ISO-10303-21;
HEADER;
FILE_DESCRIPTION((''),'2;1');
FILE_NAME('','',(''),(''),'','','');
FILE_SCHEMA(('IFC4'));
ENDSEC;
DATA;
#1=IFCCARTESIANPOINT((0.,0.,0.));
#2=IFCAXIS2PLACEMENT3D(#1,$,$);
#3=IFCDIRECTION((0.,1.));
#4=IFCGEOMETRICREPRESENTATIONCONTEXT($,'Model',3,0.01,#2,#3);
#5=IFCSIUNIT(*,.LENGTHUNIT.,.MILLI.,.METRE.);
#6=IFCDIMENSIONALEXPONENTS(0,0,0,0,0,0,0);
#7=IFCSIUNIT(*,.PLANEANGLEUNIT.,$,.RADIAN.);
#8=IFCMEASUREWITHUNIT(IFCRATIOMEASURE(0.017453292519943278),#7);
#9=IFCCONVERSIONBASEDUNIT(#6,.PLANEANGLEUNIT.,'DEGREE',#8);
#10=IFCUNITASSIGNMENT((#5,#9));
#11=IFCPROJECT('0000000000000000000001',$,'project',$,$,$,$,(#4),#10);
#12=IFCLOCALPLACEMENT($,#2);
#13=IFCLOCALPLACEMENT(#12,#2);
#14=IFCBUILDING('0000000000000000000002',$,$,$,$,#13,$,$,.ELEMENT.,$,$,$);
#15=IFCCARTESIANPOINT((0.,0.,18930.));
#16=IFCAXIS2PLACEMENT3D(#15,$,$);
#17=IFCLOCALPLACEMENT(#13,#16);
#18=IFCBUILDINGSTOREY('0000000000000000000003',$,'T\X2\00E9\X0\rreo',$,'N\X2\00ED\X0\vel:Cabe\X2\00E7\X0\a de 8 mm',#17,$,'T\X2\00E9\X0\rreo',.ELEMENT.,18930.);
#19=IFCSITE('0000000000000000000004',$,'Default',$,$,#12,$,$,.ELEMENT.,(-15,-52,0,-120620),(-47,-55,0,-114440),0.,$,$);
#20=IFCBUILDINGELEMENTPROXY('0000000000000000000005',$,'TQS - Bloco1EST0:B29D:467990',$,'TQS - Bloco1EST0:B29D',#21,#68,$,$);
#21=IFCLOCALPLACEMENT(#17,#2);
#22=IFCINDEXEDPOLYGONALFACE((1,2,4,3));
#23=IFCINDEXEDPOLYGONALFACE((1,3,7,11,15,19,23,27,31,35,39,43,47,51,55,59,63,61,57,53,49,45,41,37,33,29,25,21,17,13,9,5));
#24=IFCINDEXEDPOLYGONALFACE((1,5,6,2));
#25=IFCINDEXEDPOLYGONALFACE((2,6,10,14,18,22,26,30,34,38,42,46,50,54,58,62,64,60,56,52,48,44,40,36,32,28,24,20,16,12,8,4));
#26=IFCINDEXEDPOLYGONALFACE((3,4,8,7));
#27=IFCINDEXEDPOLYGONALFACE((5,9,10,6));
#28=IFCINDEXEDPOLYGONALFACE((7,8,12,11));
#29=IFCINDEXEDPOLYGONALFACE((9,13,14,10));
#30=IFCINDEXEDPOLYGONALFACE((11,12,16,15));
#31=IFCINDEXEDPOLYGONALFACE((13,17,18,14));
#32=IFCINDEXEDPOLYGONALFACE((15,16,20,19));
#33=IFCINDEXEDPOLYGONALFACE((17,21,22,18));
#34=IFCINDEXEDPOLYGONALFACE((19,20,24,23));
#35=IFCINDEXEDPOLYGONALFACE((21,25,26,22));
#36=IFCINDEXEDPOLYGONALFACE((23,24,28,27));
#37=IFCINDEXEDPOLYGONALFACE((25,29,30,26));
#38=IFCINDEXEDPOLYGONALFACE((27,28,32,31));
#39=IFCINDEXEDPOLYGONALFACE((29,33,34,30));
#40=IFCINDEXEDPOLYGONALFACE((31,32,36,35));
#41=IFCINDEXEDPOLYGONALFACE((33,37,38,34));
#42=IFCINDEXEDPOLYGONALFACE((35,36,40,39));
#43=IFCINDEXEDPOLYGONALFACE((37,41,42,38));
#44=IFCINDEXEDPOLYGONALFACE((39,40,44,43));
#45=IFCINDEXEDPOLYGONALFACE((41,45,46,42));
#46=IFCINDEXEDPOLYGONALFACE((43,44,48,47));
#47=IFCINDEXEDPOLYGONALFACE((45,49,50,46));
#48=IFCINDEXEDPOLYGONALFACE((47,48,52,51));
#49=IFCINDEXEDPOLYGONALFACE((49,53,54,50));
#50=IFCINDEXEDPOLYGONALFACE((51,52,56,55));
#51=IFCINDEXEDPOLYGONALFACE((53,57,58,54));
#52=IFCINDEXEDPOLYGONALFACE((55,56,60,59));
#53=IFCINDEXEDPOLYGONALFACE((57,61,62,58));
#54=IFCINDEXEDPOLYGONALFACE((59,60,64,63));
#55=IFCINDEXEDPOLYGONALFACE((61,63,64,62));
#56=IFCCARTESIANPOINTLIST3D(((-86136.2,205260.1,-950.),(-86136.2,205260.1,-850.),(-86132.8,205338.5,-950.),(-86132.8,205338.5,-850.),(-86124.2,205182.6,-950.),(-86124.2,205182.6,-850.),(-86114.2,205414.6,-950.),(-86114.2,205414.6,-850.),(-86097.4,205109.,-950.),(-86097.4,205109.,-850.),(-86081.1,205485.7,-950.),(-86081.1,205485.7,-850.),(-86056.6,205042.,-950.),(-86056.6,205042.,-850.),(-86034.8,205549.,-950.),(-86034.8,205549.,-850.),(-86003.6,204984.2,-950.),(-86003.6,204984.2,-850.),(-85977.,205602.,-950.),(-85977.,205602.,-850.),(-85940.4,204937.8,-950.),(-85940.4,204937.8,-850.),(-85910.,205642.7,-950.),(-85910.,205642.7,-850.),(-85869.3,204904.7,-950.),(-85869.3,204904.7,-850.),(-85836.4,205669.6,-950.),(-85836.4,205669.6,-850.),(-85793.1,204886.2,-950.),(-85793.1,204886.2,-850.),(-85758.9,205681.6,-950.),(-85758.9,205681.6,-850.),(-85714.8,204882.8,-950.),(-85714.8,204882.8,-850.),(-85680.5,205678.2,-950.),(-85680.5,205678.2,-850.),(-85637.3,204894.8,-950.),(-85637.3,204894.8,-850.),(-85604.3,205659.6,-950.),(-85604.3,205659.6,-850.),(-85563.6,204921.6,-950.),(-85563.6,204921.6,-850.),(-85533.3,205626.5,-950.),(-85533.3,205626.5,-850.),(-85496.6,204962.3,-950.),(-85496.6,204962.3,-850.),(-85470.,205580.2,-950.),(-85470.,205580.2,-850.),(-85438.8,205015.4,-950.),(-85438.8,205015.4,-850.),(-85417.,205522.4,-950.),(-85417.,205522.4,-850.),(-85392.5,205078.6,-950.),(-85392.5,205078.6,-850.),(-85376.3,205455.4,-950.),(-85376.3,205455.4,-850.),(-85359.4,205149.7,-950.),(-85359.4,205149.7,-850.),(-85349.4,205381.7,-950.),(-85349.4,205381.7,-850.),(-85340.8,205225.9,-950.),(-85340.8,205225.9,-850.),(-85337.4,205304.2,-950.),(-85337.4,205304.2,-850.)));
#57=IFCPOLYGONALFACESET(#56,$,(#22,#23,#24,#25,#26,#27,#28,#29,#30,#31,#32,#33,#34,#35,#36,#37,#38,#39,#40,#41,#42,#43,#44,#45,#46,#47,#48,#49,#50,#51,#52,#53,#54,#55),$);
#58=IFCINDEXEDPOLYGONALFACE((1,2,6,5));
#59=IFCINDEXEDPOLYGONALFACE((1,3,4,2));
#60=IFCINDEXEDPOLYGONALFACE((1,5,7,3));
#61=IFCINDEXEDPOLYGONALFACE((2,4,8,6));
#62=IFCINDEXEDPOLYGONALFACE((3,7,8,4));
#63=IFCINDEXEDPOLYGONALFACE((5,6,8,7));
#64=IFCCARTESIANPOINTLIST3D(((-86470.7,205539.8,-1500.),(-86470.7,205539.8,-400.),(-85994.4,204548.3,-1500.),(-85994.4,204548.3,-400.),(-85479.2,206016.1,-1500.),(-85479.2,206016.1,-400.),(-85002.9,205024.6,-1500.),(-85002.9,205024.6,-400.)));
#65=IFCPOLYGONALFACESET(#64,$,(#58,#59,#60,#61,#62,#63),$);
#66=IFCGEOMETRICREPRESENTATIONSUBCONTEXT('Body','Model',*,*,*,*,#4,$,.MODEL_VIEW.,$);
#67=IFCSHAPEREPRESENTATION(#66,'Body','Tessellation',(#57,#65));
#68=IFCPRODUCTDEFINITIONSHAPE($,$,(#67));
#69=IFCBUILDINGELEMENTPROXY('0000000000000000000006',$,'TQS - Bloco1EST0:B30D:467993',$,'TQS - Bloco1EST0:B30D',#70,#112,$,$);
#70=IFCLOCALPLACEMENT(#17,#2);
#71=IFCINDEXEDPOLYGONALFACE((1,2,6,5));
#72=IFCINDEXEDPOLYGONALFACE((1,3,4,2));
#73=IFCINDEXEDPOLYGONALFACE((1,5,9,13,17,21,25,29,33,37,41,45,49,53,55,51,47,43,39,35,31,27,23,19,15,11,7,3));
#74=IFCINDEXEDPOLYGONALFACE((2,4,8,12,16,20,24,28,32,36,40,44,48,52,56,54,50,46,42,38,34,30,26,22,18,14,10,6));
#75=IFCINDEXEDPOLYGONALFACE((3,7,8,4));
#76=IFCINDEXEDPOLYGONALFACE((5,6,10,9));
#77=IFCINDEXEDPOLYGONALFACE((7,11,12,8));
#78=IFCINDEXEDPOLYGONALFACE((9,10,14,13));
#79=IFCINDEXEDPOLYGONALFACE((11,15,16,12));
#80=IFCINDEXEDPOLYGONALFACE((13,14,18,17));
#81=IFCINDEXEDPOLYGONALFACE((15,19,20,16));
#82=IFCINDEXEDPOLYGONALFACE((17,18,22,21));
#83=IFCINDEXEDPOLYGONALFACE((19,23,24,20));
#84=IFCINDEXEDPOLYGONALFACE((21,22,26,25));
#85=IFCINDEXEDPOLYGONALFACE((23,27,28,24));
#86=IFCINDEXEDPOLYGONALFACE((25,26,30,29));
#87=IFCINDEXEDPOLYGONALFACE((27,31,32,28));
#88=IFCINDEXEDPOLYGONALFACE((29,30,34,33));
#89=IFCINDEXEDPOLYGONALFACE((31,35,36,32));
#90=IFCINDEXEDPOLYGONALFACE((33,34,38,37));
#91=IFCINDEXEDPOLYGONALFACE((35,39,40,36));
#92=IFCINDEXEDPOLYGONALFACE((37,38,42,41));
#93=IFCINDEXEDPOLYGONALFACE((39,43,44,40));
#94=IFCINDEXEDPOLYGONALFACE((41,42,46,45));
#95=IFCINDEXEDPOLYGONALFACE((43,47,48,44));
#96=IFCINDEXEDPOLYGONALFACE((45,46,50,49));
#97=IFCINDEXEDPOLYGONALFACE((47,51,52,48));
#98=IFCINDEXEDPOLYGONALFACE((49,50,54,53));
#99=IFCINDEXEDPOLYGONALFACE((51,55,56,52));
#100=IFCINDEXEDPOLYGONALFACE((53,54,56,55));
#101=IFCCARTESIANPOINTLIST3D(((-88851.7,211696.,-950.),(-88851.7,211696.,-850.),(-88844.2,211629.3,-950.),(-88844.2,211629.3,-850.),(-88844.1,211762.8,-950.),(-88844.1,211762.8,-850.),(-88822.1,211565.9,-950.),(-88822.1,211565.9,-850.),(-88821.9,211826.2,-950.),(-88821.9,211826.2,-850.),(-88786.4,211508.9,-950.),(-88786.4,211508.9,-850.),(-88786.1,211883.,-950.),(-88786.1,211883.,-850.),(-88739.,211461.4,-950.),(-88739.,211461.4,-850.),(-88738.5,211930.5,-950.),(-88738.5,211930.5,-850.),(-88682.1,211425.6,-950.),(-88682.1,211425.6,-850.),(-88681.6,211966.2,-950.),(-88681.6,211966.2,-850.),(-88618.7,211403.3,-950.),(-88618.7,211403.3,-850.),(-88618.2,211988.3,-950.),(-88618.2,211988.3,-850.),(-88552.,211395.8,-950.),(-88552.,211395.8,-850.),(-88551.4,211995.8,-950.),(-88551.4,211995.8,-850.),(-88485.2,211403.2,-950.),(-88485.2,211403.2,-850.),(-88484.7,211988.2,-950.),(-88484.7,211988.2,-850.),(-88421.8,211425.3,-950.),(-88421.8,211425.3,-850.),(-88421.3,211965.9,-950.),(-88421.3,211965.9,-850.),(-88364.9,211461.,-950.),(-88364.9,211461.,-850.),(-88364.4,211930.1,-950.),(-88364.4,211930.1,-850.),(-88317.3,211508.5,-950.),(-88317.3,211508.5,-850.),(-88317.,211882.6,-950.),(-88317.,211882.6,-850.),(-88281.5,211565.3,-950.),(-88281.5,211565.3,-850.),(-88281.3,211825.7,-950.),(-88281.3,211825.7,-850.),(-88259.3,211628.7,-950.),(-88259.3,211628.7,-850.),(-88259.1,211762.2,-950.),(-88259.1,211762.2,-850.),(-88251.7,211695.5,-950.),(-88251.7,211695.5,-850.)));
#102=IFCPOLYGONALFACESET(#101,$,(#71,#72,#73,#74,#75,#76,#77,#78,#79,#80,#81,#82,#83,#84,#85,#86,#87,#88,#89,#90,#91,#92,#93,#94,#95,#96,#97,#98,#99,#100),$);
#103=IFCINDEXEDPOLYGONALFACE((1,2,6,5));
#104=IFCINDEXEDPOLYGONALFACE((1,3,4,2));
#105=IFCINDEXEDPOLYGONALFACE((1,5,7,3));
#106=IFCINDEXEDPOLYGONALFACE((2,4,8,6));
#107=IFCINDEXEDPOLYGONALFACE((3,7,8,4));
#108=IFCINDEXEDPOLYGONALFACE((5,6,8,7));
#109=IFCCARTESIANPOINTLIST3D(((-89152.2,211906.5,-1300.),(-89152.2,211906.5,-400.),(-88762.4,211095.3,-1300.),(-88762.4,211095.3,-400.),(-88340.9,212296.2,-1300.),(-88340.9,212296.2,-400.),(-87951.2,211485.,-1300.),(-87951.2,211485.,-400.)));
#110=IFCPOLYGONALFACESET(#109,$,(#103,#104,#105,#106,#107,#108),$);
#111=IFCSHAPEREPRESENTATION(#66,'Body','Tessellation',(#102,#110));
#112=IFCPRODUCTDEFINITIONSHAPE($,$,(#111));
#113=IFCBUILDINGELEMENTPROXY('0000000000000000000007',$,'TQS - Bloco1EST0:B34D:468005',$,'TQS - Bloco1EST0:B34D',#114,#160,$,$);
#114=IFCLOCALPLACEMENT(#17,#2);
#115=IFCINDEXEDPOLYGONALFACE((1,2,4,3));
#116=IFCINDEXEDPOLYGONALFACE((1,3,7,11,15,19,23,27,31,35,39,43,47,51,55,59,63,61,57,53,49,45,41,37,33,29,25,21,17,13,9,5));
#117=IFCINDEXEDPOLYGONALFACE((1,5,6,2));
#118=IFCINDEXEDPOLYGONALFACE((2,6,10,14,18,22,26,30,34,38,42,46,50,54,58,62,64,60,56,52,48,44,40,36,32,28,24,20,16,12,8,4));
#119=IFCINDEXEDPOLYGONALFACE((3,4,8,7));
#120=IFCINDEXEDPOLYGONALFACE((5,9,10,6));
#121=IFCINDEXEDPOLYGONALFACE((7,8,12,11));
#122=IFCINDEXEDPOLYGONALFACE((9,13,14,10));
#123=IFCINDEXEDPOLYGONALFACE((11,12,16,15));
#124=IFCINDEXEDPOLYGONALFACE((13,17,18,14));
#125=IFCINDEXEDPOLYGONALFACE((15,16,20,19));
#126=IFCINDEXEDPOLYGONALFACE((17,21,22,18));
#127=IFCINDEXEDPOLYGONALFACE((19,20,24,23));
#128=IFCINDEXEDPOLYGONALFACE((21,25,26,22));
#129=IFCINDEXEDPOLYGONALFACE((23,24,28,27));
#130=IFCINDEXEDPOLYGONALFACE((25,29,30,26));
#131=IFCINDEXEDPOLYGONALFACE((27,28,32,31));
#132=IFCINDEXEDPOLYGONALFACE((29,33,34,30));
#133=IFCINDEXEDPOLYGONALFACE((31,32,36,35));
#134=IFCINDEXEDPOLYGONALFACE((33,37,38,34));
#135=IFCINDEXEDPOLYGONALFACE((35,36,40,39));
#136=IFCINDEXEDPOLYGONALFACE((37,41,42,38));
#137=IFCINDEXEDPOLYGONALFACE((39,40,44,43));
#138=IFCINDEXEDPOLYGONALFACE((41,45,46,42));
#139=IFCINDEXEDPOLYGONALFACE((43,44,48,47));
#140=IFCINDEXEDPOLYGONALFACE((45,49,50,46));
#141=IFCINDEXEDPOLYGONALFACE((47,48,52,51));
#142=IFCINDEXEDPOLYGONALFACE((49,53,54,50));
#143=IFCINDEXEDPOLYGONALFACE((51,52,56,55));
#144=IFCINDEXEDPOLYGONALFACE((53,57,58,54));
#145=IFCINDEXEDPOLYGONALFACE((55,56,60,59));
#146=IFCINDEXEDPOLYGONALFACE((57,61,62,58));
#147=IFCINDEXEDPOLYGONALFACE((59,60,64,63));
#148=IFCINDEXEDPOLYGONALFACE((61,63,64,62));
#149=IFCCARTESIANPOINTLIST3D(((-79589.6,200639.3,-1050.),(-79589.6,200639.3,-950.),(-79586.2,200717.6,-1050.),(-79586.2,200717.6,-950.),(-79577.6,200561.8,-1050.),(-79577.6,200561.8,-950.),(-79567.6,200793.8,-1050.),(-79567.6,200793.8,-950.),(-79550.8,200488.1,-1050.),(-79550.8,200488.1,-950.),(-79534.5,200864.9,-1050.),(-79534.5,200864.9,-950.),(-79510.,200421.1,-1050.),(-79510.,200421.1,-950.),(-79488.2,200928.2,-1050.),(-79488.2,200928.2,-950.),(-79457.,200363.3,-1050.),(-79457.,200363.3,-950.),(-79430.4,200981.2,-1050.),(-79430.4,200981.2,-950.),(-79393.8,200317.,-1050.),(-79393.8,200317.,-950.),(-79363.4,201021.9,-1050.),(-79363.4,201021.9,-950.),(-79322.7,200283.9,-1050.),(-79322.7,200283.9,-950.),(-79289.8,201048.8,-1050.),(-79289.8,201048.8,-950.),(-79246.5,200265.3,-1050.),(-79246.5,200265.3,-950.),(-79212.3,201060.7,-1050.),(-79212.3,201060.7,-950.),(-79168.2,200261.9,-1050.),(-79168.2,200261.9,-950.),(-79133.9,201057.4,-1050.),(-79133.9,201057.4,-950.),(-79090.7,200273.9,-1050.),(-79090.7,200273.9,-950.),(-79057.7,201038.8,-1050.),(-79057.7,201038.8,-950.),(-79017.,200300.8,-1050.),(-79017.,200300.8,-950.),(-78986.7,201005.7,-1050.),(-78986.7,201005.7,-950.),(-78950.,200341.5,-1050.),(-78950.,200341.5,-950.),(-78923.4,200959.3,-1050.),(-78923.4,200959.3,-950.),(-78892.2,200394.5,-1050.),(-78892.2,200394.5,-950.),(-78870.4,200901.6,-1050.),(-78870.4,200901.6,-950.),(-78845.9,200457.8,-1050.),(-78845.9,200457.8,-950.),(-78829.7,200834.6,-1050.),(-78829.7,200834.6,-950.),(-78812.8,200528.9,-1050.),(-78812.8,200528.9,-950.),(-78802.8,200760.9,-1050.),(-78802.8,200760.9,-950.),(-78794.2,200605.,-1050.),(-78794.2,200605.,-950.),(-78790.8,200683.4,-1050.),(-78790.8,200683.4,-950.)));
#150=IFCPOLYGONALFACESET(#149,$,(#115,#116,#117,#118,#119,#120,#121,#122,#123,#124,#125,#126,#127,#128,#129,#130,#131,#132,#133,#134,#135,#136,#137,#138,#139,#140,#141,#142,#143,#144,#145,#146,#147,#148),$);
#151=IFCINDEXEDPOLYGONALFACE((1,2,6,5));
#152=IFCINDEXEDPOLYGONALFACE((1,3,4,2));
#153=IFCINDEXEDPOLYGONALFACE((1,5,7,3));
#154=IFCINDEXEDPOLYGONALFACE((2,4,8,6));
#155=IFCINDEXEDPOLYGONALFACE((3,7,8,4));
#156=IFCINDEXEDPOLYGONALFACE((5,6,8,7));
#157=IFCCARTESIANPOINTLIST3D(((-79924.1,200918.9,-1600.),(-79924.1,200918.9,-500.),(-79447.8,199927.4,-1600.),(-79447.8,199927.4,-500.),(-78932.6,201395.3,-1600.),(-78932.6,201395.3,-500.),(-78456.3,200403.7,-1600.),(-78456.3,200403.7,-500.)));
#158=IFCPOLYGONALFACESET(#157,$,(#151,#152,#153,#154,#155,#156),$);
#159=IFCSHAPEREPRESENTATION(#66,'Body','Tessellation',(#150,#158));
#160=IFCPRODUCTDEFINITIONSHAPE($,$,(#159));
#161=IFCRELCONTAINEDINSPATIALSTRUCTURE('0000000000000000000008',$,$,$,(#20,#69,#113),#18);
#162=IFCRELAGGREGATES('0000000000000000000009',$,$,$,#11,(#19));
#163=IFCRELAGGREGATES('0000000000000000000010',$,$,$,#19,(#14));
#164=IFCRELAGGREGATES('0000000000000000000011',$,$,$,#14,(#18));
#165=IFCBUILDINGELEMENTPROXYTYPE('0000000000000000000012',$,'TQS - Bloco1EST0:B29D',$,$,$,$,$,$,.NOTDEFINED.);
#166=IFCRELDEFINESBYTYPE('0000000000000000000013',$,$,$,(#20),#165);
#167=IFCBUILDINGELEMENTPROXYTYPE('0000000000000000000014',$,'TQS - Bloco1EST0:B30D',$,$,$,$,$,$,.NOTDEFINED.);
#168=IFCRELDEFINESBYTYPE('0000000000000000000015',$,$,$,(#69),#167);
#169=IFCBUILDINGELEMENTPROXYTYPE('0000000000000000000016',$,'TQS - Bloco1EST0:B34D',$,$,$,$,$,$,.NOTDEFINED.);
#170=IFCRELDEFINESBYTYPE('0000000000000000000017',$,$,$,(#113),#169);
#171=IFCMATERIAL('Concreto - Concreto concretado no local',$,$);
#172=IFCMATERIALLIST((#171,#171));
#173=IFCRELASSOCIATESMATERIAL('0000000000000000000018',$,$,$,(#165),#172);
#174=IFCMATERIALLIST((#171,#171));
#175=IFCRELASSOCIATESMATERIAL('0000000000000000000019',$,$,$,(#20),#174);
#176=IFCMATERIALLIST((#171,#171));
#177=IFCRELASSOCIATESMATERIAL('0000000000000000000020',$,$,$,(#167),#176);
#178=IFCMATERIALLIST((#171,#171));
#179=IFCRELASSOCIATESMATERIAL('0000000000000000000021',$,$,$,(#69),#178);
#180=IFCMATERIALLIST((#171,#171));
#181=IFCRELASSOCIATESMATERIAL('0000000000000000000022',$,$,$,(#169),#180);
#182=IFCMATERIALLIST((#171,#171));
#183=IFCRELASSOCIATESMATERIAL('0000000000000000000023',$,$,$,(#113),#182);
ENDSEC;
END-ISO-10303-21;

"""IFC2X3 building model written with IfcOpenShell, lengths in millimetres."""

from ifc_helpers import new_model, entity, si_unit, converted_unit, direction, frame, frame_2d, origin, origin_2d_with_axis, place, context, subcontext, project, spatial, rectangle, circle, extrude, source, transform, mapped, material, material_list, type_object, type_shapes, element, save


model = new_model("IFC2X3")

# Units and contexts
model_context = context("Model", 3, precision=0.01, world=origin(), true_north=direction((0.0, 1.0)))
body_context = subcontext(model_context, "Body", "Model", "MODEL_VIEW")
ifc_project = project(units=[si_unit("LENGTHUNIT", "METRE", prefix="MILLI"), converted_unit("PLANEANGLEUNIT", "DEGREE", entity("IfcRatioMeasure", 0.017453292519943278), si_unit("PLANEANGLEUNIT", "RADIAN"), dimensions=[0, 0, 0, 0, 0, 0, 0])], contexts=[model_context])

# Site, building, storey
site_placement = place(None, origin())
site = spatial("IfcSite", under=ifc_project, at=site_placement, Name="Default", CompositionType="ELEMENT", RefLatitude=(-15, -52, 0, -120620), RefLongitude=(-47, -55, 0, -114440), RefElevation=0.0)
building_placement = place(site_placement, origin())
building = spatial("IfcBuilding", under=site, at=building_placement, CompositionType="ELEMENT")
storey_placement = place(building_placement, frame((0.0, 0.0, 18930.0)))
storey = spatial("IfcBuildingStorey", under=building, at=storey_placement, Name="Térreo", ObjectType="Nível:Cabeça de 8 mm", LongName="Térreo", CompositionType="ELEMENT", Elevation=18930.0)

# Building element proxies
ifc_material_1 = material(Name="Concreto - Concreto concretado no local")
ifc_material_list_1 = material_list([ifc_material_1, ifc_material_1])
ifc_material_list_2 = material_list([ifc_material_1, ifc_material_1])
building_element_proxy_type_1 = type_object("IfcBuildingElementProxyType", Name="TQS - Bloco1EST0:B29D", PredefinedType="NOTDEFINED", material=ifc_material_list_2)
shared_shape_1 = source(origin(), body_context, "Body", "SweptSolid", [
    extrude(circle(Radius=400.0, at=frame_2d((0.0, 0.0), x_axis=(1.0, 0.0))), frame((0.0, 0.0, -550.0)), (0.0, 0.0, 1.0), 100.0),
    extrude(rectangle(XDim=1100.0, YDim=1100.0, at=origin_2d_with_axis()), frame((0.0, 0.0, -1100.0), z_axis=(0.0, 0.0, 1.0), x_axis=(-1.0, 0.0, 0.0)), (0.0, 0.0, 1.0), 1100.0),
])
type_shapes(building_element_proxy_type_1, [shared_shape_1])
proxy_1_placement = place(storey_placement, frame((-85736.8, 205282.2, -400.0), z_axis=(0.0, 0.0, 1.0), x_axis=(-0.43303, 0.90138, 0.0)))
element("IfcBuildingElementProxy", 1, at=proxy_1_placement, inside=storey, type_object=building_element_proxy_type_1, material=ifc_material_list_1, Name="TQS - Bloco1EST0:B29D:467990", ObjectType="TQS - Bloco1EST0:B29D", context=body_context, shape_type="MappedRepresentation", body=[
    mapped(shared_shape_1, transform((0.0, 0.0, 0.0), scale=1.0)),
])
ifc_material_list_3 = material_list([ifc_material_1, ifc_material_1])
ifc_material_list_4 = material_list([ifc_material_1, ifc_material_1])
building_element_proxy_type_2 = type_object("IfcBuildingElementProxyType", Name="TQS - Bloco1EST0:B30D", PredefinedType="NOTDEFINED", material=ifc_material_list_4)
shared_shape_2 = source(origin(), body_context, "Body", "SweptSolid", [
    extrude(circle(Radius=300.0, at=frame_2d((0.0, 0.0), x_axis=(1.0, 0.0))), frame((0.0, 0.0, -550.0)), (0.0, 0.0, 1.0), 100.0),
    extrude(rectangle(XDim=900.0, YDim=900.0, at=origin_2d_with_axis()), frame((0.0, 0.0, -900.0), z_axis=(0.0, 0.0, 1.0), x_axis=(-1.0, 0.0, 0.0)), (0.0, 0.0, 1.0), 900.0),
])
type_shapes(building_element_proxy_type_2, [shared_shape_2])
proxy_2_placement = place(storey_placement, frame((-88551.7, 211695.8, -400.0), z_axis=(0.0, 0.0, 1.0), x_axis=(-0.43303, 0.90138, 0.0)))
element("IfcBuildingElementProxy", 2, at=proxy_2_placement, inside=storey, type_object=building_element_proxy_type_2, material=ifc_material_list_3, Name="TQS - Bloco1EST0:B30D:467993", ObjectType="TQS - Bloco1EST0:B30D", context=body_context, shape_type="MappedRepresentation", body=[
    mapped(shared_shape_2, transform((0.0, 0.0, 0.0), scale=1.0)),
])
ifc_material_list_5 = material_list([ifc_material_1, ifc_material_1])
ifc_material_list_6 = material_list([ifc_material_1, ifc_material_1])
building_element_proxy_type_3 = type_object("IfcBuildingElementProxyType", Name="TQS - Bloco1EST0:B34D", PredefinedType="NOTDEFINED", material=ifc_material_list_6)
shared_shape_3 = source(origin(), body_context, "Body", "SweptSolid", [
    extrude(circle(Radius=400.0, at=frame_2d((0.0, 0.0), x_axis=(1.0, 0.0))), frame((0.0, 0.0, -550.0)), (0.0, 0.0, 1.0), 100.0),
    extrude(rectangle(XDim=1100.0, YDim=1100.0, at=origin_2d_with_axis()), frame((0.0, 0.0, -1100.0), z_axis=(0.0, 0.0, 1.0), x_axis=(-1.0, 0.0, 0.0)), (0.0, 0.0, 1.0), 1100.0),
])
type_shapes(building_element_proxy_type_3, [shared_shape_3])
proxy_3_placement = place(storey_placement, frame((-79190.2, 200661.3, -500.0), z_axis=(0.0, 0.0, 1.0), x_axis=(-0.43303, 0.90138, 0.0)))
element("IfcBuildingElementProxy", 3, at=proxy_3_placement, inside=storey, type_object=building_element_proxy_type_3, material=ifc_material_list_5, Name="TQS - Bloco1EST0:B34D:468005", ObjectType="TQS - Bloco1EST0:B34D", context=body_context, shape_type="MappedRepresentation", body=[
    mapped(shared_shape_3, transform((0.0, 0.0, 0.0), scale=1.0)),
])

save(model, "model.ifc")
